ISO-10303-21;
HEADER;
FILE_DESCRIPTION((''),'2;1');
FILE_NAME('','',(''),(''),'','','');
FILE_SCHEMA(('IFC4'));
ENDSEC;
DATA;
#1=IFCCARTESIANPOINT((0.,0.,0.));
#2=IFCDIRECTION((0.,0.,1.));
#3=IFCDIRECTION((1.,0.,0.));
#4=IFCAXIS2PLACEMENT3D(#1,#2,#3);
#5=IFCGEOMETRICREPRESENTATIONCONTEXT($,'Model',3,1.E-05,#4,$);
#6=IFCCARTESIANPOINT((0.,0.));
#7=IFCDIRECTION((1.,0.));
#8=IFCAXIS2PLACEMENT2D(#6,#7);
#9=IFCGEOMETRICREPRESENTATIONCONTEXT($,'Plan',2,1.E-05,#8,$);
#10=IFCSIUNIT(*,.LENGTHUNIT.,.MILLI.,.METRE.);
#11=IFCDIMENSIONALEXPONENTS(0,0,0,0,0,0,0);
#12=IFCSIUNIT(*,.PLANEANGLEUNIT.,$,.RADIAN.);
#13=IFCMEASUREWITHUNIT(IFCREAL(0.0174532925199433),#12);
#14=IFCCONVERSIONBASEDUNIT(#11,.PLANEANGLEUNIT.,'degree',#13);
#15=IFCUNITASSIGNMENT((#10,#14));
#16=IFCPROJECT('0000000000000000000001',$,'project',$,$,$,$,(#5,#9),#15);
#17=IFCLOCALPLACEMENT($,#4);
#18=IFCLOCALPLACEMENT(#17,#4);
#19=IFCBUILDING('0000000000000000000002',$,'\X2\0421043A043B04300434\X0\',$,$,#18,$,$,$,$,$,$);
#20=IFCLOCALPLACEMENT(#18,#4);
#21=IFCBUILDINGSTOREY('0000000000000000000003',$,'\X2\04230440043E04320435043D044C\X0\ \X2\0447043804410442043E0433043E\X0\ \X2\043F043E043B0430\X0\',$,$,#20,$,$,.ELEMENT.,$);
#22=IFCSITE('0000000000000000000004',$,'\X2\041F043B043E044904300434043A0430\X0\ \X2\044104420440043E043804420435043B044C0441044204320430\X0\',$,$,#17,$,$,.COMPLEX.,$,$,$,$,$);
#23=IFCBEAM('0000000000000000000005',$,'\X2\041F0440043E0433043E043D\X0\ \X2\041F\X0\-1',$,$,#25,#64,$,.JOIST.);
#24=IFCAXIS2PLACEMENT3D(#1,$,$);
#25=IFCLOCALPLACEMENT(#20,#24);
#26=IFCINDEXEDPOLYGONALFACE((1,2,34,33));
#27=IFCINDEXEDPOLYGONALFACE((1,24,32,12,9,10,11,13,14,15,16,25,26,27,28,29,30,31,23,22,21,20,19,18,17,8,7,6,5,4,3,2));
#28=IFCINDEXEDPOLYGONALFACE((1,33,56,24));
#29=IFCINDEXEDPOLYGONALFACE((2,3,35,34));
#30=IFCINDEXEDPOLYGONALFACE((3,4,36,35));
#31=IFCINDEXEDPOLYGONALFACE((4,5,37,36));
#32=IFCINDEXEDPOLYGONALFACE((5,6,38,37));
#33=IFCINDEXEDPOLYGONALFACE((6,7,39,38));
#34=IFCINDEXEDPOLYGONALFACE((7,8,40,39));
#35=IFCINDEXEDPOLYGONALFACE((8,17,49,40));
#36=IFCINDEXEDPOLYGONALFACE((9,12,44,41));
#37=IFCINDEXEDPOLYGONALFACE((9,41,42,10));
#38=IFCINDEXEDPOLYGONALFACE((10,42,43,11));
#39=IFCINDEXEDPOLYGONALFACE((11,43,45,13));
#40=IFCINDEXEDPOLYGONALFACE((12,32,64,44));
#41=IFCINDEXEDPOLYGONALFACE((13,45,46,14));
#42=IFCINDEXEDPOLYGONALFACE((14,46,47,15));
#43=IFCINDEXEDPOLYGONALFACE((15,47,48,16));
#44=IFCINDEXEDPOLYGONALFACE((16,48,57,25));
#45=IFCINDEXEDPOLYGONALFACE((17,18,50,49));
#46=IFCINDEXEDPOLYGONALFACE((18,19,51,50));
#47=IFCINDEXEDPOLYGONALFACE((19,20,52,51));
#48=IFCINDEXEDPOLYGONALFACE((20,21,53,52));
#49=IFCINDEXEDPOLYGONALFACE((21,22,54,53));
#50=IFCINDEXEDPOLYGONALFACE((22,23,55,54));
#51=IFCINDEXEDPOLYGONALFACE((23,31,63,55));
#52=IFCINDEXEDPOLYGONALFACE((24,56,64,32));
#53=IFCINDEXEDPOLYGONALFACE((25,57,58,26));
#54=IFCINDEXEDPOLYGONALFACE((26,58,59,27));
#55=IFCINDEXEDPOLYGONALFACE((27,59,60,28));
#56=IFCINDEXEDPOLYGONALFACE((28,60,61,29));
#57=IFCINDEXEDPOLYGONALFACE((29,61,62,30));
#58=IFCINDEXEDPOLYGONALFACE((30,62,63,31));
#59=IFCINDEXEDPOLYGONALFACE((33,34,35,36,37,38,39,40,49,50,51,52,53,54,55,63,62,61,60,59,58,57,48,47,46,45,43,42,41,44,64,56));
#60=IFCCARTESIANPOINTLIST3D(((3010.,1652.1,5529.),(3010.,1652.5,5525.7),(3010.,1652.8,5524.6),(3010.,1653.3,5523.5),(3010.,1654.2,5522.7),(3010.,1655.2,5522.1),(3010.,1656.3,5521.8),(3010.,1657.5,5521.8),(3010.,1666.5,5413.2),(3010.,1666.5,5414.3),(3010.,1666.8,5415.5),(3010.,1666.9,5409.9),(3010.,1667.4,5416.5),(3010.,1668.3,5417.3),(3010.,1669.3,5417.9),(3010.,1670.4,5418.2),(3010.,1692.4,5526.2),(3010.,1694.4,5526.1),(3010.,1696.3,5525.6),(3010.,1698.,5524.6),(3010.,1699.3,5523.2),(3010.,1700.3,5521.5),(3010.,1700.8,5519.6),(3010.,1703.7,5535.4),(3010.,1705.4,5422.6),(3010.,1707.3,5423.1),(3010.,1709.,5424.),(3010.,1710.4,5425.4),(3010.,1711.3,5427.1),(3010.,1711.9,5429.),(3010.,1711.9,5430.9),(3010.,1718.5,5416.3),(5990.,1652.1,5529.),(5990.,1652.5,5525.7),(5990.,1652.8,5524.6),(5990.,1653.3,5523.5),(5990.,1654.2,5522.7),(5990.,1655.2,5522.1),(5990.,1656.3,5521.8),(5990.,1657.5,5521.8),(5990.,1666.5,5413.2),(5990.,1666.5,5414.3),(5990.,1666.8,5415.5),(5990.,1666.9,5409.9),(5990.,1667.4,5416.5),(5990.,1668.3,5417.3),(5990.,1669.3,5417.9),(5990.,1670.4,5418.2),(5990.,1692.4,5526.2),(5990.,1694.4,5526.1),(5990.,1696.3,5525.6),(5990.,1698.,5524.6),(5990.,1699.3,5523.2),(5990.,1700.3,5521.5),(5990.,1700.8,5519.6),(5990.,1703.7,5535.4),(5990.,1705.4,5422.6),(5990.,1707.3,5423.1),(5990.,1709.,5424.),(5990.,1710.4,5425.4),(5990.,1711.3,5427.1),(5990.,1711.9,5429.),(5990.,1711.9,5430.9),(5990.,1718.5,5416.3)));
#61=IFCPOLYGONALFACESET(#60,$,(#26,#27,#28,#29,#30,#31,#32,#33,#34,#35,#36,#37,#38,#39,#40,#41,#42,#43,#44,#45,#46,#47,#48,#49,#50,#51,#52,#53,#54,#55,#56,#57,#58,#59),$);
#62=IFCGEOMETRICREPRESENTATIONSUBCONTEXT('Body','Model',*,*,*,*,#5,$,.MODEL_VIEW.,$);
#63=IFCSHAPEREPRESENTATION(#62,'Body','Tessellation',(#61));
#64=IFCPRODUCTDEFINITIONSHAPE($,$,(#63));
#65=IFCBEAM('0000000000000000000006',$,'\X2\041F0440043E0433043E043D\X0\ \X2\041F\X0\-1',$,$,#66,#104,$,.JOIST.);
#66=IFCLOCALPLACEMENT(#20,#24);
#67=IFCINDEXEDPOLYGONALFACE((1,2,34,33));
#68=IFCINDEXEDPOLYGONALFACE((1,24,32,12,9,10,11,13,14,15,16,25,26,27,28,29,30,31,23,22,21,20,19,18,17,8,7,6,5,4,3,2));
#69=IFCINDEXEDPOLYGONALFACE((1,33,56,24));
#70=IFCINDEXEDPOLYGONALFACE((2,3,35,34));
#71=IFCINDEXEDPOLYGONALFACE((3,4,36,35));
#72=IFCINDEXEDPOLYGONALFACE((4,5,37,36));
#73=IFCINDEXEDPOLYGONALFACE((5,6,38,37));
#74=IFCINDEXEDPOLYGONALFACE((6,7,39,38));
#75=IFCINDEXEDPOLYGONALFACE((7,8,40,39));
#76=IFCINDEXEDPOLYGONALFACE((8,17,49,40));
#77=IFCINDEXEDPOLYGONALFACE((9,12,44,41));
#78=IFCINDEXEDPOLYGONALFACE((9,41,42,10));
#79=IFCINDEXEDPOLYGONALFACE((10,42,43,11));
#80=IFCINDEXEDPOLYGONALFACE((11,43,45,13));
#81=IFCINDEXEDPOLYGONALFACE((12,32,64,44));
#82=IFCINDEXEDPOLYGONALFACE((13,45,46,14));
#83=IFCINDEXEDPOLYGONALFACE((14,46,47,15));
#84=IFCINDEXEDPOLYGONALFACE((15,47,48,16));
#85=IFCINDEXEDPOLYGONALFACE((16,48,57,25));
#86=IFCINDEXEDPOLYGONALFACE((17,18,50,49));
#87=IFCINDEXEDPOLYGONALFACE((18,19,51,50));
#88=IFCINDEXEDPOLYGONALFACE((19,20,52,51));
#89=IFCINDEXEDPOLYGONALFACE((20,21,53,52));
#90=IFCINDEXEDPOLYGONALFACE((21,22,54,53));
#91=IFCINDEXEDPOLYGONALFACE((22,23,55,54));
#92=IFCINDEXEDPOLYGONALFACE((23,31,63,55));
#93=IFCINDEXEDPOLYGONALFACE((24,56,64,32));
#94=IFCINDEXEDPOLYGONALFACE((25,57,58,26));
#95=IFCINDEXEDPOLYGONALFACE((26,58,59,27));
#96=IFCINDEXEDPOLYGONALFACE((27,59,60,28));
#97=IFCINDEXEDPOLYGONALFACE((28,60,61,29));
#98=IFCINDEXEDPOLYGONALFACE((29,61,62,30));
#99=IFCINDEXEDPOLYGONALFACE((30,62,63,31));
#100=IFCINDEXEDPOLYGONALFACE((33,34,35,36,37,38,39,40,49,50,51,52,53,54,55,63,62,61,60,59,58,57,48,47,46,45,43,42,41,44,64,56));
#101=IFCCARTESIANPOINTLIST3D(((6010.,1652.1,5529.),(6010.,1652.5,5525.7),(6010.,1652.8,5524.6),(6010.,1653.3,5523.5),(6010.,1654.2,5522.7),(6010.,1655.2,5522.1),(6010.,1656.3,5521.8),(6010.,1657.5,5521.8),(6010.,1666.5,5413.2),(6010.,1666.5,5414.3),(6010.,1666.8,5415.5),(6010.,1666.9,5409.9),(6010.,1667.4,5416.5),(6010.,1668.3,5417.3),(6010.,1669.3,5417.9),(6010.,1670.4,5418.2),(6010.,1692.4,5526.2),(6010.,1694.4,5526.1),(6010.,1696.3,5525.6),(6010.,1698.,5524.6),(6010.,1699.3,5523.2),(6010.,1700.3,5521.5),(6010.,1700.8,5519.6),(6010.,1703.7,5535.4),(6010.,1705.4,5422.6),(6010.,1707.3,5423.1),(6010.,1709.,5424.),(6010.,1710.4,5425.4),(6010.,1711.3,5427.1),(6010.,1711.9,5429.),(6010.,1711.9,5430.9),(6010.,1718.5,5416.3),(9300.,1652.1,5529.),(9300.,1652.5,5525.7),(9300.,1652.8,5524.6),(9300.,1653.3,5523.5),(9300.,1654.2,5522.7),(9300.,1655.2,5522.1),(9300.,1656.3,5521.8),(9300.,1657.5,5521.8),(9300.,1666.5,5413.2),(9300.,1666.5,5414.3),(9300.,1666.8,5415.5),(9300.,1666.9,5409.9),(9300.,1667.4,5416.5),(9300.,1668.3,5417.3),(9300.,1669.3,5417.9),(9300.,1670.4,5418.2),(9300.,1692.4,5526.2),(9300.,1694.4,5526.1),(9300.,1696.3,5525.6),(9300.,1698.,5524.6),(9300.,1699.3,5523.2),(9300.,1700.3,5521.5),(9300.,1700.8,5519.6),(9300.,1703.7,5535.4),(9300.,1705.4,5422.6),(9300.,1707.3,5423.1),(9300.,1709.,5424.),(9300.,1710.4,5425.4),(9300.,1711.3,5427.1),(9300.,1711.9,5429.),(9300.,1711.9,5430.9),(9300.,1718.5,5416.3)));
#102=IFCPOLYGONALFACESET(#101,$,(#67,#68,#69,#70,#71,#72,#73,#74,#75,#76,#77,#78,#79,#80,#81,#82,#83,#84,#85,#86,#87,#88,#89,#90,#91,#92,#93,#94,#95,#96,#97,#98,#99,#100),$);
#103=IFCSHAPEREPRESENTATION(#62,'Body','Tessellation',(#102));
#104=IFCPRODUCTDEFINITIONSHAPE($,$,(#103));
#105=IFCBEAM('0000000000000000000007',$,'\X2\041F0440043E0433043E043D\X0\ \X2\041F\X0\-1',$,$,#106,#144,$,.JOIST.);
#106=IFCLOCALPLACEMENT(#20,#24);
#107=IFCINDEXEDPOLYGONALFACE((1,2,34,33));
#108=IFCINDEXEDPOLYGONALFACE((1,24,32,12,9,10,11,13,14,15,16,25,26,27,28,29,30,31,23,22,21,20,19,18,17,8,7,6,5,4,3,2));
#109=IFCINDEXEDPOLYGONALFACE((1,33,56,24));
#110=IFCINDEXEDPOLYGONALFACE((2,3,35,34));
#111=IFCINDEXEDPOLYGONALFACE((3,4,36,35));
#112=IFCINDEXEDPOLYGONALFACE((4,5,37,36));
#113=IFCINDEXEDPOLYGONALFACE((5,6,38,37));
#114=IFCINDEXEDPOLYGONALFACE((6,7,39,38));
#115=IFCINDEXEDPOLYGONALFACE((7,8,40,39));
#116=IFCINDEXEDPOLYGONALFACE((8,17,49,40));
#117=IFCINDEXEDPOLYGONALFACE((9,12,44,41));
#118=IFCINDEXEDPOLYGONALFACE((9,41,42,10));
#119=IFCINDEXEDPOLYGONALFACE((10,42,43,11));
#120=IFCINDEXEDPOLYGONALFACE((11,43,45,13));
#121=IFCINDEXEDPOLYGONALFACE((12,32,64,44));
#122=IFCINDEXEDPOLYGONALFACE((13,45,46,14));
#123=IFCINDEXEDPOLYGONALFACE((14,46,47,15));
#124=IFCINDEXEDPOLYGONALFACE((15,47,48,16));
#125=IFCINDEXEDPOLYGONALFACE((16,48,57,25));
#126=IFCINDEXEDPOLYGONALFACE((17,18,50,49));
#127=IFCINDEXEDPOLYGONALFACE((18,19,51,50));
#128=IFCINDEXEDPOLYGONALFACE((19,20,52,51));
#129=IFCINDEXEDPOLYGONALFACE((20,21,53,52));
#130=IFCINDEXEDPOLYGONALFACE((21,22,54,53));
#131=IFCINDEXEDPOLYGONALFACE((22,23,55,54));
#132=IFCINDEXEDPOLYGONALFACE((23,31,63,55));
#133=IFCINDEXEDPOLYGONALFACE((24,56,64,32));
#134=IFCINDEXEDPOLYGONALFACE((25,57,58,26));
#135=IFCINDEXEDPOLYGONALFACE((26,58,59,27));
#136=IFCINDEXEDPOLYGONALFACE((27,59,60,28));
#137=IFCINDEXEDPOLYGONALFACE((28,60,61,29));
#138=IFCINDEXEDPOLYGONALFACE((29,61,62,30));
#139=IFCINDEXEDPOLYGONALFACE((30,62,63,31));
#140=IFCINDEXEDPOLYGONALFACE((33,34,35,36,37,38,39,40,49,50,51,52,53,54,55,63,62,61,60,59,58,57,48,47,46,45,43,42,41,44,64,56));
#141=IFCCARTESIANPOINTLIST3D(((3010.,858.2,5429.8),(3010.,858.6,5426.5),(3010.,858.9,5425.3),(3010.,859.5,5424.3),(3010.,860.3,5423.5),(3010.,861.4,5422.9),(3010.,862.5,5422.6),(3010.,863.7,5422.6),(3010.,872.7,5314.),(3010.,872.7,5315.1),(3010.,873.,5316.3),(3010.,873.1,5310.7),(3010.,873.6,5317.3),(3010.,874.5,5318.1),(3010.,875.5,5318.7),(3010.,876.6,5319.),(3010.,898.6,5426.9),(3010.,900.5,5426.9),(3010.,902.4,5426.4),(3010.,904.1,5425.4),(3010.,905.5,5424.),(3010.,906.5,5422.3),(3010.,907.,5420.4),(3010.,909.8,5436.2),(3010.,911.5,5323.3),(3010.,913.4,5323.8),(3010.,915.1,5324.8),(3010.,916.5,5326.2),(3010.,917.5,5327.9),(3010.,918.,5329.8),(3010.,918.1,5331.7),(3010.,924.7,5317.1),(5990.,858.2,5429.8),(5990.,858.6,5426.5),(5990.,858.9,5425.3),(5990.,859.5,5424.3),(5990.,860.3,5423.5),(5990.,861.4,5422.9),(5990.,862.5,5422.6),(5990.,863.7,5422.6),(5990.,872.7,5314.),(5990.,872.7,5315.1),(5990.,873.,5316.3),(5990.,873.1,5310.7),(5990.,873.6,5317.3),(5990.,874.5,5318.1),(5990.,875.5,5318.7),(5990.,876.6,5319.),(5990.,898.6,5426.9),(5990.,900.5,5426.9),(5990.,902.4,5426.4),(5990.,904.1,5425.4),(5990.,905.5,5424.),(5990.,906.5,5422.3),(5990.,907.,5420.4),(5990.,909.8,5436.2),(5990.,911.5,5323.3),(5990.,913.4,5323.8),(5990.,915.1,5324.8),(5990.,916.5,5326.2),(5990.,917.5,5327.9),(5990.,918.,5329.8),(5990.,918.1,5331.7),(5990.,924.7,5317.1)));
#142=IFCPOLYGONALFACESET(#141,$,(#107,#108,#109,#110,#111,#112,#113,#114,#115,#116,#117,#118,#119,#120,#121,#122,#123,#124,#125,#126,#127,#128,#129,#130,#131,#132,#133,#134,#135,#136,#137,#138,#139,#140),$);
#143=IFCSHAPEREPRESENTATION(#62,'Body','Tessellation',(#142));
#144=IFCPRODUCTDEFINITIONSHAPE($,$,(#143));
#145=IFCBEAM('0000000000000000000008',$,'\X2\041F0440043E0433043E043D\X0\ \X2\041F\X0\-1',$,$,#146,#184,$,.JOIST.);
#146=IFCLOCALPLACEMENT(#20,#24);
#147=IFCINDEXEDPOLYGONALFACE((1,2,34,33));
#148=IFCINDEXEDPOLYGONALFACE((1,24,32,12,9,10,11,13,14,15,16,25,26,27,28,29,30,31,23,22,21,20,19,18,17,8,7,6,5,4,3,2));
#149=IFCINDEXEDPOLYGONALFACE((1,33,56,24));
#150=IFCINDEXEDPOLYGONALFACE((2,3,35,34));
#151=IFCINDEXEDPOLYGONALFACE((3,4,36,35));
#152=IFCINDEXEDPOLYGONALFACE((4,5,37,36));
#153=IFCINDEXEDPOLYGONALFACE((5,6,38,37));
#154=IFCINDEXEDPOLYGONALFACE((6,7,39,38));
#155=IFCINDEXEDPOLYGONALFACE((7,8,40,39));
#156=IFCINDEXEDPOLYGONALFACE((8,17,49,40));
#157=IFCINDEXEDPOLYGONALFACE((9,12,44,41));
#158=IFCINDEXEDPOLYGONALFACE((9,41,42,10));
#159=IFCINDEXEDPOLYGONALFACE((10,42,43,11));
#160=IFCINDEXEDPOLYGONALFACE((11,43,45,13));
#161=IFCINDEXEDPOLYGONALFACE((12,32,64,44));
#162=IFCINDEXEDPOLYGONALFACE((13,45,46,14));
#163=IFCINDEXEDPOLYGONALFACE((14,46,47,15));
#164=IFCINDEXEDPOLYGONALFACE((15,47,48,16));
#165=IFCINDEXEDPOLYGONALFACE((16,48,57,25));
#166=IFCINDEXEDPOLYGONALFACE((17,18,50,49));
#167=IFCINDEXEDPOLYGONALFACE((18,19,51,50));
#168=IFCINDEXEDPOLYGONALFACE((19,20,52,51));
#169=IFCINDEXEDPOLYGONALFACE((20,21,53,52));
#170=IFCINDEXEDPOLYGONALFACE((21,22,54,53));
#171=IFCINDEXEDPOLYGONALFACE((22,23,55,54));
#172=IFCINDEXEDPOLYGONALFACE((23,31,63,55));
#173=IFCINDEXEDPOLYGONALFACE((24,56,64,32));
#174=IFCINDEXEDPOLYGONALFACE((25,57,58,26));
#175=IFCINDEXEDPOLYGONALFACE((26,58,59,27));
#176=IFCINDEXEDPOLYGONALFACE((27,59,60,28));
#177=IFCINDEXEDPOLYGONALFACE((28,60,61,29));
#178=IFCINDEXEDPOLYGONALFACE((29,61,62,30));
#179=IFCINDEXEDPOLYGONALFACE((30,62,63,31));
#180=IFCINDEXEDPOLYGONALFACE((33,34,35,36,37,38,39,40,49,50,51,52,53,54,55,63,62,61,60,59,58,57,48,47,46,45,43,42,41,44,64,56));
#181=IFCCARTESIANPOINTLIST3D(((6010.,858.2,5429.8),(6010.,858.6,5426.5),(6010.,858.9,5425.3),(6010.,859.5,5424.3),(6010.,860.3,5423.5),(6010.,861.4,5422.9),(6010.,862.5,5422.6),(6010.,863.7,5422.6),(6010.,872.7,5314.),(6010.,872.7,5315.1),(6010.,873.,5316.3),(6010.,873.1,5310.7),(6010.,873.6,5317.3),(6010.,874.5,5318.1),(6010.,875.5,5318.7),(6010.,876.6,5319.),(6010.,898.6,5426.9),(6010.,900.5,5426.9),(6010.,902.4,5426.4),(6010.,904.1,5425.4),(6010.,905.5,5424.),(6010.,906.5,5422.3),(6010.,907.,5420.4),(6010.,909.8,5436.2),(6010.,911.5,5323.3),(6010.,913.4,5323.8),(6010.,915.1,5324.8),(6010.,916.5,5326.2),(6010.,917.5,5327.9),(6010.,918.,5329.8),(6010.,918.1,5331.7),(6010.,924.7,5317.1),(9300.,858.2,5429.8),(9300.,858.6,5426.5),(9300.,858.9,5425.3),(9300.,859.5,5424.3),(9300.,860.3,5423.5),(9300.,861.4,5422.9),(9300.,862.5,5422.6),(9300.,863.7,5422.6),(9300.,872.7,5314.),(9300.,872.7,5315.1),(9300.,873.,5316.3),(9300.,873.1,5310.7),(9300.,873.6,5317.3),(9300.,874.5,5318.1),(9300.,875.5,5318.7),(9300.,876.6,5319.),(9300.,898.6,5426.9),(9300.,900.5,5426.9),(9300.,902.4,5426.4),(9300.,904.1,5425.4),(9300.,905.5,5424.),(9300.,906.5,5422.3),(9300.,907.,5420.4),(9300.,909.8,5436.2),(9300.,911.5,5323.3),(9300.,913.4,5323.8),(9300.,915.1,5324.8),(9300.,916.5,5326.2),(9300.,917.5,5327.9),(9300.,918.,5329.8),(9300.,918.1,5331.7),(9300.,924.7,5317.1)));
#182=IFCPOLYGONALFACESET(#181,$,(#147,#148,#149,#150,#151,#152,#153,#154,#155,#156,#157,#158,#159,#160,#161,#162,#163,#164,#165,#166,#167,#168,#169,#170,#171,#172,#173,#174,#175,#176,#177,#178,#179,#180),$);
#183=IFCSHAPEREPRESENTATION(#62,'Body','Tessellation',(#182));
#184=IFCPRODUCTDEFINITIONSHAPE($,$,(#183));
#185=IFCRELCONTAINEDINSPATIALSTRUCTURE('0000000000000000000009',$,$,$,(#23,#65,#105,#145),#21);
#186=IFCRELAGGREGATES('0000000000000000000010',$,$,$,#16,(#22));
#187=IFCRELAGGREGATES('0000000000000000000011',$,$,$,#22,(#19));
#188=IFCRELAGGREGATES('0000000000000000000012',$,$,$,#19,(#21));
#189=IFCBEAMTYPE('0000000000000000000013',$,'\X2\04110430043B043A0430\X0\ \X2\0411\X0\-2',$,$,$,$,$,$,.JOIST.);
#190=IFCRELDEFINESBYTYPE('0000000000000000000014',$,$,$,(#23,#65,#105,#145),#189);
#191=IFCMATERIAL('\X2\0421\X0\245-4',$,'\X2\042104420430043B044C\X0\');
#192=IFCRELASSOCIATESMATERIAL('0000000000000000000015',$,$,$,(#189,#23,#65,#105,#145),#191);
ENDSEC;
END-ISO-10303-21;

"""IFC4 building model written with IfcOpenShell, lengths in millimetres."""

from ifc_helpers import new_model, entity, si_unit, converted_unit, frame, origin_with_axes, origin_2d_with_axis, place, context, subcontext, project, spatial, u_section, extrude, material, material_profile, profile_set, profile_usage, type_object, element, save


model = new_model("IFC4")

# Units and contexts
model_context = context("Model", 3, precision=1e-05, world=origin_with_axes())
plan_context = context("Plan", 2, precision=1e-05, world=origin_2d_with_axis())
body_context = subcontext(model_context, "Body", "Model", "MODEL_VIEW")
ifc_project = project(units=[si_unit("LENGTHUNIT", "METRE", prefix="MILLI"), converted_unit("PLANEANGLEUNIT", "degree", entity("IfcReal", 0.0174532925199433), si_unit("PLANEANGLEUNIT", "RADIAN"), dimensions=[0, 0, 0, 0, 0, 0, 0])], contexts=[model_context, plan_context])

# Site, building, storey
site_placement = place(None, origin_with_axes())
site = spatial("IfcSite", under=ifc_project, at=site_placement, Name="Площадка строительства", CompositionType="COMPLEX")
building_placement = place(site_placement, origin_with_axes())
building = spatial("IfcBuilding", under=site, at=building_placement, Name="Склад")
storey_placement = place(building_placement, origin_with_axes())
storey = spatial("IfcBuildingStorey", under=building, at=storey_placement, Name="Уровень чистого пола", CompositionType="ELEMENT")

# Beams
ifc_material_1 = material(Name="С245-4", Category="Сталь")
ifc_material_profile_1 = material_profile(ifc_material_1, u_section(Depth=120.0, FlangeWidth=52.0, WebThickness=4.8, FlangeThickness=7.8, FilletRadius=7.5, EdgeRadius=4.5, FlangeSlope=0.0))
ifc_profile_set_1 = profile_set([ifc_material_profile_1], Name="U12P_S245-4")
ifc_profile_usage_1 = profile_usage(ifc_profile_set_1, cardinal=3)
beam_type_1 = type_object("IfcBeamType", Name="Балка Б-2", PredefinedType="JOIST", material=ifc_profile_set_1)
beam_1_placement = place(storey_placement, frame((5990.0, 1718.5, 5416.3), z_axis=(-1.0, 0.0, 0.0), x_axis=(0.0, -0.99228, -0.12402)))
element("IfcBeam", 1, at=beam_1_placement, inside=storey, type_object=beam_type_1, material=ifc_profile_usage_1, Name="Прогон П-1", PredefinedType="JOIST", context=body_context, shape_type="SweptSolid", body=[
    extrude(u_section(Depth=120.0, FlangeWidth=52.0, WebThickness=4.8, FlangeThickness=7.8, FilletRadius=7.5, EdgeRadius=4.5, FlangeSlope=0.0), frame((26.0, 60.0, 0.0), z_axis=(0.0, 0.0, 1.0), x_axis=(1.0, 0.0, 0.0)), (0.0, 0.0, 1.0), 2980.0),
])
beam_2_placement = place(storey_placement, frame((9300.0, 1718.5, 5416.3), z_axis=(-1.0, 0.0, 0.0), x_axis=(0.0, -0.99228, -0.12402)))
element("IfcBeam", 2, at=beam_2_placement, inside=storey, type_object=beam_type_1, material=ifc_profile_usage_1, Name="Прогон П-1", PredefinedType="JOIST", context=body_context, shape_type="SweptSolid", body=[
    extrude(u_section(Depth=120.0, FlangeWidth=52.0, WebThickness=4.8, FlangeThickness=7.8, FilletRadius=7.5, EdgeRadius=4.5, FlangeSlope=0.0), frame((26.0, 60.0, 0.0), z_axis=(0.0, 0.0, 1.0), x_axis=(1.0, 0.0, 0.0)), (0.0, 0.0, 1.0), 3290.0),
])
beam_3_placement = place(storey_placement, frame((5990.0, 924.7, 5317.1), z_axis=(-1.0, 0.0, 0.0), x_axis=(0.0, -0.99228, -0.12402)))
element("IfcBeam", 3, at=beam_3_placement, inside=storey, type_object=beam_type_1, material=ifc_profile_usage_1, Name="Прогон П-1", PredefinedType="JOIST", context=body_context, shape_type="SweptSolid", body=[
    extrude(u_section(Depth=120.0, FlangeWidth=52.0, WebThickness=4.8, FlangeThickness=7.8, FilletRadius=7.5, EdgeRadius=4.5, FlangeSlope=0.0), frame((26.0, 60.0, 0.0), z_axis=(0.0, 0.0, 1.0), x_axis=(1.0, 0.0, 0.0)), (0.0, 0.0, 1.0), 2980.0),
])
beam_4_placement = place(storey_placement, frame((9300.0, 924.7, 5317.1), z_axis=(-1.0, 0.0, 0.0), x_axis=(0.0, -0.99228, -0.12402)))
element("IfcBeam", 4, at=beam_4_placement, inside=storey, type_object=beam_type_1, material=ifc_profile_usage_1, Name="Прогон П-1", PredefinedType="JOIST", context=body_context, shape_type="SweptSolid", body=[
    extrude(u_section(Depth=120.0, FlangeWidth=52.0, WebThickness=4.8, FlangeThickness=7.8, FilletRadius=7.5, EdgeRadius=4.5, FlangeSlope=0.0), frame((26.0, 60.0, 0.0), z_axis=(0.0, 0.0, 1.0), x_axis=(1.0, 0.0, 0.0)), (0.0, 0.0, 1.0), 3290.0),
])

save(model, "model.ifc")
